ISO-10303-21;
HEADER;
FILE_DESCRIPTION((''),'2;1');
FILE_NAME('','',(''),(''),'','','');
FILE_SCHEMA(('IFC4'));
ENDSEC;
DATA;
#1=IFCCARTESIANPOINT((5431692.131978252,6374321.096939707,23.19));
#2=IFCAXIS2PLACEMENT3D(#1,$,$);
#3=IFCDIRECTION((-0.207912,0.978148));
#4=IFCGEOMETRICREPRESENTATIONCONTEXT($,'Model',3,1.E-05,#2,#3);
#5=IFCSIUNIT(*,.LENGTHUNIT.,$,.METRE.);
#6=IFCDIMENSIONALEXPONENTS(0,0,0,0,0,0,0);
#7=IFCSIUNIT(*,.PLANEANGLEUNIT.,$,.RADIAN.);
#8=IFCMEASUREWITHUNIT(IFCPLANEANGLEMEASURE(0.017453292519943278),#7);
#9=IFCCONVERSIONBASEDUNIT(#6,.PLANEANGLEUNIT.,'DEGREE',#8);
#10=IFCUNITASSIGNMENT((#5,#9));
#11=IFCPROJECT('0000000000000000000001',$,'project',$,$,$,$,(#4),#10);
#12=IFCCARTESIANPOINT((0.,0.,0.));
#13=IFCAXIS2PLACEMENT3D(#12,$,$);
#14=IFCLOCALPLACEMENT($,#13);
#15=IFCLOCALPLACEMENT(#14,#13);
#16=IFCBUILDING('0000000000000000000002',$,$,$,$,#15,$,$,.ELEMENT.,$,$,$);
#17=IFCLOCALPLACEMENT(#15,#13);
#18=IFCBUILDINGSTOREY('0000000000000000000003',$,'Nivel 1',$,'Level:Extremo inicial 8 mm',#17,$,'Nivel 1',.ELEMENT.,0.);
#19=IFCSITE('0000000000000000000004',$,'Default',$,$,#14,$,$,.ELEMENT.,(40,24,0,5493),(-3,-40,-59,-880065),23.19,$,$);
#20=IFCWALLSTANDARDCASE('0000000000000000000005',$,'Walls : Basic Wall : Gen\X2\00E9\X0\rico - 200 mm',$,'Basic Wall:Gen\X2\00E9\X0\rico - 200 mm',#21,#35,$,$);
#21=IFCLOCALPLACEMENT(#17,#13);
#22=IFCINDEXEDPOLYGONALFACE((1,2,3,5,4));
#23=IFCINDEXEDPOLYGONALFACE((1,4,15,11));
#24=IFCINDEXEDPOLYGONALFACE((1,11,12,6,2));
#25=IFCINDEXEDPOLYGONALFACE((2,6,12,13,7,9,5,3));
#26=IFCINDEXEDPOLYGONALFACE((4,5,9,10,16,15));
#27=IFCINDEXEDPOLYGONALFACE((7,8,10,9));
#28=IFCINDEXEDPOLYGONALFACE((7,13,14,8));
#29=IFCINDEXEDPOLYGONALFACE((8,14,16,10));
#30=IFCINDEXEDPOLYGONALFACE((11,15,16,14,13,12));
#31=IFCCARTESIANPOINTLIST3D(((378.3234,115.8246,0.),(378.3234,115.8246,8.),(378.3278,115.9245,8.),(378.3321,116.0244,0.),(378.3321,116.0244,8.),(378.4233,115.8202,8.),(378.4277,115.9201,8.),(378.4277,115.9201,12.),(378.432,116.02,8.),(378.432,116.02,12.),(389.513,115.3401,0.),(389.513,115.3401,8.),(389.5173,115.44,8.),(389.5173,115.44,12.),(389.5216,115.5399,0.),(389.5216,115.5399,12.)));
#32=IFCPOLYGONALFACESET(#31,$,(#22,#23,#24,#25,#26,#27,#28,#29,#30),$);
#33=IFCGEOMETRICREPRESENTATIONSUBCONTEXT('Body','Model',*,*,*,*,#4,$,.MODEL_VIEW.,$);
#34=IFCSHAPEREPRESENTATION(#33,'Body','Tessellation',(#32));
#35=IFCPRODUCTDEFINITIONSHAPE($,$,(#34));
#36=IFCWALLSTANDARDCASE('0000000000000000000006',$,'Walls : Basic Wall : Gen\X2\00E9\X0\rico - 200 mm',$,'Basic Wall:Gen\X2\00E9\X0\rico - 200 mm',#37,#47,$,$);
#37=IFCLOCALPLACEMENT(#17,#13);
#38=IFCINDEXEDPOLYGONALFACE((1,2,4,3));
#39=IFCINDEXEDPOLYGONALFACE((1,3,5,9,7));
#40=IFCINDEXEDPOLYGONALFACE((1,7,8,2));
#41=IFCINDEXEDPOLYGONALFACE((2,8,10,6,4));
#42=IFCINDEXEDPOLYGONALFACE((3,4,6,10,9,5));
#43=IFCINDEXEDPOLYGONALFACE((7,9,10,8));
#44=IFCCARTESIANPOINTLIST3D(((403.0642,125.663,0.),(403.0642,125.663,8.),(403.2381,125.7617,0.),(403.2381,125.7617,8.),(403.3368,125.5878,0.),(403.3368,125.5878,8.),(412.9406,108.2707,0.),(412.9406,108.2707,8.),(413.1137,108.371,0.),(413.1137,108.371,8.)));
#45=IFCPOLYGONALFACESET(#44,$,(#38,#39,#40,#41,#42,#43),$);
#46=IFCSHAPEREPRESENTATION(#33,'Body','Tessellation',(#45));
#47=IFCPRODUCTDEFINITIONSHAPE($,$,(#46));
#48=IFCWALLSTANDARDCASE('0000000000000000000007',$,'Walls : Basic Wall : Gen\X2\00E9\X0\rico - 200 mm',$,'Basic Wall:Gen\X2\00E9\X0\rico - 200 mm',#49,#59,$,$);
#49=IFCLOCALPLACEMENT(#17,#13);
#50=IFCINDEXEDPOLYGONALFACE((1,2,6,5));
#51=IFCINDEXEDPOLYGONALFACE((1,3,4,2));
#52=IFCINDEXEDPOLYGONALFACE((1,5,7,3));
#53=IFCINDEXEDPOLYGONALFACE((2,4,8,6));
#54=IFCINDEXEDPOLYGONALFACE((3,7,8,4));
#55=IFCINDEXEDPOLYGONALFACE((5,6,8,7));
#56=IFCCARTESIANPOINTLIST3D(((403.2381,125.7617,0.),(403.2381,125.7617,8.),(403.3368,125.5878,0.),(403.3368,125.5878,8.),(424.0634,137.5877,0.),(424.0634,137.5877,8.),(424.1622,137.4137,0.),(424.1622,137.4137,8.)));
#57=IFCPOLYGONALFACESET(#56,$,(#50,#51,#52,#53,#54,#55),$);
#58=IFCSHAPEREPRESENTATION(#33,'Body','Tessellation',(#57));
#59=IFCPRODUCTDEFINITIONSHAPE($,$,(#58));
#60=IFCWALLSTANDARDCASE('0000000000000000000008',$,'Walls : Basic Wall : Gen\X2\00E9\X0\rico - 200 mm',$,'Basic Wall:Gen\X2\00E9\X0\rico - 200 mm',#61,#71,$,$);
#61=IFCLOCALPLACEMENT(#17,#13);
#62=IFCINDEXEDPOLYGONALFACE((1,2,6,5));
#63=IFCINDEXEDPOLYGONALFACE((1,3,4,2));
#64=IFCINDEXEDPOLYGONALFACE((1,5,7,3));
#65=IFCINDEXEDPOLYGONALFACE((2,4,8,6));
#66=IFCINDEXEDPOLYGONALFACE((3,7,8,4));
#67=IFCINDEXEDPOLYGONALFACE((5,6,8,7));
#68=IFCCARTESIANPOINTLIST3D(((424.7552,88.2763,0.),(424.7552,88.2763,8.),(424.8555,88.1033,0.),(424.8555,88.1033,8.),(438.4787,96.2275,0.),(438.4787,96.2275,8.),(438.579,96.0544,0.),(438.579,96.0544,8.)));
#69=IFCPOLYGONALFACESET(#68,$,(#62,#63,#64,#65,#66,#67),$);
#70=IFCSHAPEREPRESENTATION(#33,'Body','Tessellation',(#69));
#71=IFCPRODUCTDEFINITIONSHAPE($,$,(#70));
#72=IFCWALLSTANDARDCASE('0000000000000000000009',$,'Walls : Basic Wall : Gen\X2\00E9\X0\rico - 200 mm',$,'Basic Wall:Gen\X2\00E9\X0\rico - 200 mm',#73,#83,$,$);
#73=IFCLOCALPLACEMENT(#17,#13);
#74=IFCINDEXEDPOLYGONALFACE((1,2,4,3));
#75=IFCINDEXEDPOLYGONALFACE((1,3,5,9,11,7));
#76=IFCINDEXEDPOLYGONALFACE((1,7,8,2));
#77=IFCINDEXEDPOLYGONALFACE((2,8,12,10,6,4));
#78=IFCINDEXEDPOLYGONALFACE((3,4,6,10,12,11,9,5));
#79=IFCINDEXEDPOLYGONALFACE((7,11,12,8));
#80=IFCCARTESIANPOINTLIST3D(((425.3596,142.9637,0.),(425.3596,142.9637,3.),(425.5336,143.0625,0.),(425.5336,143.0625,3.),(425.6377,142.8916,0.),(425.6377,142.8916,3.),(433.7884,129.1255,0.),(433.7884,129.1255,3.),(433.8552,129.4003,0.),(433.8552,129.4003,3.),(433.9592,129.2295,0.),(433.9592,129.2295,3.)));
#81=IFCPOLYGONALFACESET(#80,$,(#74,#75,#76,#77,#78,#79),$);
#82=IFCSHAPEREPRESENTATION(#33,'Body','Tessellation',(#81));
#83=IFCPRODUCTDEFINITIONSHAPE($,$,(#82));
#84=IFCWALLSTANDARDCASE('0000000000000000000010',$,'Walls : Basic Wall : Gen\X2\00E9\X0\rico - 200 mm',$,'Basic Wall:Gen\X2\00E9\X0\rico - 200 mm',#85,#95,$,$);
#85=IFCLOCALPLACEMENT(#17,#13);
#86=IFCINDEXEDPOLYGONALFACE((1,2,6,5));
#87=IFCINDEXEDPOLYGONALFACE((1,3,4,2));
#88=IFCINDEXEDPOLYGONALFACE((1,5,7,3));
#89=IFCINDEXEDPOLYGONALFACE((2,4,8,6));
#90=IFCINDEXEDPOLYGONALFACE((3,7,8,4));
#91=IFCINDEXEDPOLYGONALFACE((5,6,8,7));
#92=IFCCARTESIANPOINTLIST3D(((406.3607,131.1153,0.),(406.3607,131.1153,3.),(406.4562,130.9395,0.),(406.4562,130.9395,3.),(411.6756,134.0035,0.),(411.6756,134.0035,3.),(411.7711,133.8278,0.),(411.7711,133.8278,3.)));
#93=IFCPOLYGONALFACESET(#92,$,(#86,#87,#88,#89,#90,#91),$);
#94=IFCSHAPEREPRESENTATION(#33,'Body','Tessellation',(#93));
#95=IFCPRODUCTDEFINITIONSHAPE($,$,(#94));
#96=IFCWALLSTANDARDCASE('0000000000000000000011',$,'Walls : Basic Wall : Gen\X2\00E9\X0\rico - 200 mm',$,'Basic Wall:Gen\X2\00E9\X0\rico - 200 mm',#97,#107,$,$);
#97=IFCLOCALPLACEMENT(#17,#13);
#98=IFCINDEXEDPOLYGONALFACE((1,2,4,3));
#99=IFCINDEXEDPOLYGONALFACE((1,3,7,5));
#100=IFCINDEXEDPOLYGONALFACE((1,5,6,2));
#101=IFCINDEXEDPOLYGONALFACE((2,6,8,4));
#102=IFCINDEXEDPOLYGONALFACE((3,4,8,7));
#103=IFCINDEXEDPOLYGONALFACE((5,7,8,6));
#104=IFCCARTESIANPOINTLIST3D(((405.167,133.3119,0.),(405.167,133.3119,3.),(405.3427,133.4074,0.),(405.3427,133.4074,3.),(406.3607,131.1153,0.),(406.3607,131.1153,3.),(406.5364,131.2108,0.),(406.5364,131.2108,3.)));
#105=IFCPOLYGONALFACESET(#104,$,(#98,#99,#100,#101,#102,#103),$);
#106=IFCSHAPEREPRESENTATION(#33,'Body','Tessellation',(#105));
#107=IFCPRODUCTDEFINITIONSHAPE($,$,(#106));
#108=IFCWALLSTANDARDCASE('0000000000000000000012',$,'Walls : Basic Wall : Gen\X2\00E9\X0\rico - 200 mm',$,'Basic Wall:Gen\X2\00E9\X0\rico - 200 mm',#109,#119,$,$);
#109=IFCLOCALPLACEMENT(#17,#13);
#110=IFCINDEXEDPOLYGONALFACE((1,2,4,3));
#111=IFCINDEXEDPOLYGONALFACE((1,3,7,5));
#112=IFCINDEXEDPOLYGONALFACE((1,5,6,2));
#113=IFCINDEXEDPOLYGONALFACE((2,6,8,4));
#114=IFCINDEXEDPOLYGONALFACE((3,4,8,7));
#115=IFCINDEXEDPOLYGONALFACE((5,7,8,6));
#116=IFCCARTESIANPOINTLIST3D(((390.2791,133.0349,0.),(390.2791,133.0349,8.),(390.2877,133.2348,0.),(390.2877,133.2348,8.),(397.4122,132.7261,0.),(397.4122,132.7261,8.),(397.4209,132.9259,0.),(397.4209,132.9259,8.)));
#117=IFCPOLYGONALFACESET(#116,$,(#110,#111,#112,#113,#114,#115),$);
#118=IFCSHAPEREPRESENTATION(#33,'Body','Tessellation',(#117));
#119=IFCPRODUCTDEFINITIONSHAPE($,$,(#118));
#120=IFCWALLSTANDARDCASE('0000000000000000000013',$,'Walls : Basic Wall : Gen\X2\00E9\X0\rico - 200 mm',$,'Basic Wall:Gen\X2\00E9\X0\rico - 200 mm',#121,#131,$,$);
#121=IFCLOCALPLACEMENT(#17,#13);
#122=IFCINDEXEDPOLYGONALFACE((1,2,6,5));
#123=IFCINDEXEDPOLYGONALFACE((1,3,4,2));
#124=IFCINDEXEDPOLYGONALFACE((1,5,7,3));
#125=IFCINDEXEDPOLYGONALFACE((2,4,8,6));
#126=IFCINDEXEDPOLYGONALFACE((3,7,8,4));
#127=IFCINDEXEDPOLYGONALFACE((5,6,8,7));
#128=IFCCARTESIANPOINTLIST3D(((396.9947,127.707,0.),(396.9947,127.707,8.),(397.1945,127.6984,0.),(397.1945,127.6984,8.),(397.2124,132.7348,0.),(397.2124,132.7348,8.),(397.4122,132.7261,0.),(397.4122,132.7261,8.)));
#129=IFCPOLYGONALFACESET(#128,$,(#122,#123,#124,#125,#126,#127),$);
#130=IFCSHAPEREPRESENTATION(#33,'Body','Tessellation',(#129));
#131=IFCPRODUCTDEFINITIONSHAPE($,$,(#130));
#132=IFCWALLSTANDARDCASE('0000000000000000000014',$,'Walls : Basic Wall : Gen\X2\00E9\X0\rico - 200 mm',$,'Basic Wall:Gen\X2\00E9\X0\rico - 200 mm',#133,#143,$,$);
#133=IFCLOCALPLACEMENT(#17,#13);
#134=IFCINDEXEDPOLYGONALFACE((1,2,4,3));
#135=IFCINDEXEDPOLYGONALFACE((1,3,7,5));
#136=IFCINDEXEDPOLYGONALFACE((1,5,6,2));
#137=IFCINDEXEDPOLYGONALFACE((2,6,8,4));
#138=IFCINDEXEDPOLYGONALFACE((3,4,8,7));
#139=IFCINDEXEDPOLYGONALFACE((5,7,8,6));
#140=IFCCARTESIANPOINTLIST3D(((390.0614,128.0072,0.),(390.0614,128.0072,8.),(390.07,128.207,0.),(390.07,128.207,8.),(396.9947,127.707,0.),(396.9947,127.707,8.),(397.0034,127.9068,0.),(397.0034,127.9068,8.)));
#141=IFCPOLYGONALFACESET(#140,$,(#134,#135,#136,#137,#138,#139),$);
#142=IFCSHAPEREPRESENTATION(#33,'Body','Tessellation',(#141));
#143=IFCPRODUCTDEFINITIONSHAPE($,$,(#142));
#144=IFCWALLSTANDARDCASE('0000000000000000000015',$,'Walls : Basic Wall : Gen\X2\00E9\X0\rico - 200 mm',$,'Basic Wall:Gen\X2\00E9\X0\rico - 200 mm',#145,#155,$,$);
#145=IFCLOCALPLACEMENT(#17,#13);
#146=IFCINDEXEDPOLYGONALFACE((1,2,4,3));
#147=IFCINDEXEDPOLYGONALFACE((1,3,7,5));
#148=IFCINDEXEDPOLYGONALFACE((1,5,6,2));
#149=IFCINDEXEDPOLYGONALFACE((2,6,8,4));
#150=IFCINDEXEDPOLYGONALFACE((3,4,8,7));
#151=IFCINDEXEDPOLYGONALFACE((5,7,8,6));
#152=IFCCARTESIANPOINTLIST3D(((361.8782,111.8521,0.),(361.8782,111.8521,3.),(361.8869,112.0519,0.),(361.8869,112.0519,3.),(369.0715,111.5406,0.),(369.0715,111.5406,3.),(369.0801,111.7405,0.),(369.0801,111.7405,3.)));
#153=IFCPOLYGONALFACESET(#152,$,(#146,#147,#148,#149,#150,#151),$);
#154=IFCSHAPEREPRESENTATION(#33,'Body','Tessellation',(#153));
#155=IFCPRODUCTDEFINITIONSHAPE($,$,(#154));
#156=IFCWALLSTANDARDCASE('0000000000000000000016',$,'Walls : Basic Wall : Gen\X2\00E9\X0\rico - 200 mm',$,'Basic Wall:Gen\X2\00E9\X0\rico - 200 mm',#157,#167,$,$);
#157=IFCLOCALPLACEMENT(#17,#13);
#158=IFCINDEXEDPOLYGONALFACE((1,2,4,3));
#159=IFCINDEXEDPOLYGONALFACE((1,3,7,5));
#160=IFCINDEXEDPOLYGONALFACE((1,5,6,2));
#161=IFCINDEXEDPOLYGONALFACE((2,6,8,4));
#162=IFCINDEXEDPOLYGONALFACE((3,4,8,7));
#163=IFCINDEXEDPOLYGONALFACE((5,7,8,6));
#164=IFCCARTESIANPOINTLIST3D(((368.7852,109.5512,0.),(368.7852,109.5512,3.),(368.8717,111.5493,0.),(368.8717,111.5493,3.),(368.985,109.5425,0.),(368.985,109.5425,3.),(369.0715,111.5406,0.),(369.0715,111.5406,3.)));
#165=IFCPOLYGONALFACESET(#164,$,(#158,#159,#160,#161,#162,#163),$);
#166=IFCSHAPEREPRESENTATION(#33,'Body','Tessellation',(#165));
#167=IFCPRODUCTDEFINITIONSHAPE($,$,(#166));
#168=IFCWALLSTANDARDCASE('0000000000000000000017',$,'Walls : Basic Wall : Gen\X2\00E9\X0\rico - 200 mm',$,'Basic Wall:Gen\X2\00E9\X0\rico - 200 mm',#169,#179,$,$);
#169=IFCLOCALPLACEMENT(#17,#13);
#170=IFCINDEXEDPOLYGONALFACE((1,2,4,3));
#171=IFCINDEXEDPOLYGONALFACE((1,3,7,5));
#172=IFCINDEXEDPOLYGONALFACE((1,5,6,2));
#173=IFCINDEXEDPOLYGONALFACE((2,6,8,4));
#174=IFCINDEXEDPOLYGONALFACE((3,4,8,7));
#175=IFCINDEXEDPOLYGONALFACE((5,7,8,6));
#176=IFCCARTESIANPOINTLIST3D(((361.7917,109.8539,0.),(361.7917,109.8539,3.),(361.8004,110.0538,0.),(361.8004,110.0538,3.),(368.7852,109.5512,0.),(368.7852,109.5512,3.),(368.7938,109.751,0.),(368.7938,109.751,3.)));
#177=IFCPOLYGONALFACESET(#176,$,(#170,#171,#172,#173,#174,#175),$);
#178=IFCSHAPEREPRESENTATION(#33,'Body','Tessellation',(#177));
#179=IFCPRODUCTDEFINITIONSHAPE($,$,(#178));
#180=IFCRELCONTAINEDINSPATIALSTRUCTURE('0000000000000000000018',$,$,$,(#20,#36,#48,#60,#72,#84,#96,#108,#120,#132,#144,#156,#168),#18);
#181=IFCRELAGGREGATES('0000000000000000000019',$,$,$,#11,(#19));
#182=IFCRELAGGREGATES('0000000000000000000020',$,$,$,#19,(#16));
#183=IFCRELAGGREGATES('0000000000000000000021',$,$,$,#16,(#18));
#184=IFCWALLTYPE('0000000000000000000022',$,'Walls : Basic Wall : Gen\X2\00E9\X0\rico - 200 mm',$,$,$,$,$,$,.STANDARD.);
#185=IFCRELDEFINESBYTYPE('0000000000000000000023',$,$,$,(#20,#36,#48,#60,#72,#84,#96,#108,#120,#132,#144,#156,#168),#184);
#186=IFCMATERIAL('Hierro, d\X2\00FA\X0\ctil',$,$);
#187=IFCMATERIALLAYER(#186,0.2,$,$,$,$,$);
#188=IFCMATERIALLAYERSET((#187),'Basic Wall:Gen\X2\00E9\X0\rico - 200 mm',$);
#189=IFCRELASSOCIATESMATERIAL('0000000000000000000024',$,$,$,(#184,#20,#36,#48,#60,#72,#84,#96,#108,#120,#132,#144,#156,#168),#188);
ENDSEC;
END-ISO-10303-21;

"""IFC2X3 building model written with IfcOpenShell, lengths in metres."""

from ifc_helpers import new_model, entity, si_unit, converted_unit, direction, frame, frame_2d, origin, place, context, subcontext, project, spatial, polyline, rectangle, outline, extrude, clip, bounded_halfspace, material, layer, layer_set, layer_usage, type_object, element, save


model = new_model("IFC2X3")

# Units and contexts
model_context = context("Model", 3, precision=1e-05, world=frame((5431692.131978252, 6374321.096939707, 23.19)), true_north=direction((-0.207912, 0.978148)))
body_context = subcontext(model_context, "Body", "Model", "MODEL_VIEW")
ifc_project = project(units=[si_unit("LENGTHUNIT", "METRE"), converted_unit("PLANEANGLEUNIT", "DEGREE", entity("IfcPlaneAngleMeasure", 0.017453292519943278), si_unit("PLANEANGLEUNIT", "RADIAN"), dimensions=[0, 0, 0, 0, 0, 0, 0])], contexts=[model_context])

# Site, building, storey
site_placement = place(None, origin())
site = spatial("IfcSite", under=ifc_project, at=site_placement, Name="Default", CompositionType="ELEMENT", RefLatitude=(40, 24, 0, 5493), RefLongitude=(-3, -40, -59, -880065), RefElevation=23.19)
building_placement = place(site_placement, origin())
building = spatial("IfcBuilding", under=site, at=building_placement, CompositionType="ELEMENT")
storey_placement = place(building_placement, origin())
storey = spatial("IfcBuildingStorey", under=building, at=storey_placement, Name="Nivel 1", ObjectType="Level:Extremo inicial 8 mm", LongName="Nivel 1", CompositionType="ELEMENT", Elevation=0.0)

# Walls
ifc_material = material(Name="Hierro, dúctil")
ifc_layer = layer(ifc_material, 0.2)
ifc_layer_set = layer_set([ifc_layer], Name="Basic Wall:Genérico - 200 mm")
wall_type = type_object("IfcWallType", Name="Walls : Basic Wall : Genérico - 200 mm", PredefinedType="STANDARD", material=ifc_layer_set)
ifc_layer_usage_1 = layer_usage(ifc_layer_set, "AXIS2", "NEGATIVE", 0.1)
wall_1_placement = place(storey_placement, frame((389.5173, 115.44, 0.0), z_axis=(0.0, 0.0, 1.0), x_axis=(-0.999064, 0.043255, 0.0)))
element("IfcWallStandardCase", 1, at=wall_1_placement, inside=storey, type_object=wall_type, material=ifc_layer_usage_1, Name="Walls : Basic Wall : Genérico - 200 mm", ObjectType="Basic Wall:Genérico - 200 mm", context=body_context, shape_type="Clipping", body=[
    clip(clip(clip(clip(extrude(rectangle(XDim=11.2, YDim=0.2, at=frame_2d((5.6, 0.0), x_axis=(-1.0, 0.0))), origin(), (0.0, 0.0, 1.0), 12.0), bounded_halfspace(frame((0.0, -0.1, 12.0), z_axis=(0.0, 0.0, 1.0), x_axis=(-0.999064, -0.043255, 0.0)), False, frame((0.0, -0.1, 12.0)), polyline([(0.0, 0.0), (0.2, 0.0), (11.1, 0.0), (11.1, 0.1), (0.0, 0.1), (0.0, 0.0)]))), bounded_halfspace(frame((11.1, -0.1, 8.0), z_axis=(0.0, 0.0, 1.0), x_axis=(0.0, 1.0, 0.0)), False, frame((11.1, -0.1, 8.0)), polyline([(0.0, 0.0), (0.1, 0.0), (0.1, 0.1), (0.0, 0.1), (0.0, 0.0)]))), bounded_halfspace(frame((11.1, 0.1, 8.0), z_axis=(0.0, 0.0, 1.0), x_axis=(0.0, 1.0, 0.0)), False, frame((11.1, 0.1, 8.0)), polyline([(0.0, 0.0), (-11.1, 0.0), (-11.1, -0.1), (0.0, -0.1), (0.0, 0.0)]))), bounded_halfspace(frame((11.2, 0.0, 8.0), z_axis=(0.0, 0.0, 1.0), x_axis=(0.0, 1.0, 0.0)), False, frame((11.2, 0.0, 8.0)), polyline([(0.0, 0.0), (0.0, 0.1), (-0.1, 0.1), (-0.1, 0.0), (0.0, 0.0)]))),
])
ifc_layer_usage_2 = layer_usage(ifc_layer_set, "AXIS2", "NEGATIVE", 0.1)
wall_2_placement = place(storey_placement, frame((413.0276, 108.3201, 0.0), z_axis=(0.0, 0.0, 1.0), x_axis=(-0.4938, 0.869576, 0.0)))
element("IfcWallStandardCase", 2, at=wall_2_placement, inside=storey, type_object=wall_type, material=ifc_layer_usage_2, Name="Walls : Basic Wall : Genérico - 200 mm", ObjectType="Basic Wall:Genérico - 200 mm", context=body_context, shape_type="SweptSolid", body=[
    extrude(outline(polyline([(20.0009, -0.1), (20.0009, 0.1), (0.0, 0.1), (0.0017, -0.1), (19.8009, -0.1), (20.0009, -0.1)])), origin(), (0.0, 0.0, 1.0), 8.0),
])
ifc_layer_usage_3 = layer_usage(ifc_layer_set, "AXIS2", "NEGATIVE", 0.1)
wall_3_placement = place(storey_placement, frame((403.2875, 125.6748, 0.0), z_axis=(0.0, 0.0, 1.0), x_axis=(0.869576, 0.4938, 0.0)))
element("IfcWallStandardCase", 3, at=wall_3_placement, inside=storey, type_object=wall_type, material=ifc_layer_usage_3, Name="Walls : Basic Wall : Genérico - 200 mm", ObjectType="Basic Wall:Genérico - 200 mm", context=body_context, shape_type="SweptSolid", body=[
    extrude(rectangle(XDim=23.9488, YDim=0.2, at=frame_2d((11.9744, 0.0), x_axis=(-1.0, 0.0))), origin(), (0.0, 0.0, 1.0), 8.0),
])
ifc_layer_usage_4 = layer_usage(ifc_layer_set, "AXIS2", "NEGATIVE", 0.1)
wall_4_placement = place(storey_placement, frame((424.8053, 88.1898, 0.0), z_axis=(0.0, 0.0, 1.0), x_axis=(0.865262, 0.50132, 0.0)))
element("IfcWallStandardCase", 4, at=wall_4_placement, inside=storey, type_object=wall_type, material=ifc_layer_usage_4, Name="Walls : Basic Wall : Genérico - 200 mm", ObjectType="Basic Wall:Genérico - 200 mm", context=body_context, shape_type="SweptSolid", body=[
    extrude(rectangle(XDim=15.8605, YDim=0.2, at=frame_2d((7.9302, 0.0), x_axis=(-1.0, 0.0))), origin(), (0.0, 0.0, 1.0), 8.0),
])
ifc_layer_usage_5 = layer_usage(ifc_layer_set, "AXIS2", "NEGATIVE", 0.1)
wall_5_placement = place(storey_placement, frame((433.8738, 129.1775, 0.0), z_axis=(0.0, 0.0, 1.0), x_axis=(-0.520198, 0.854046, 0.0)))
element("IfcWallStandardCase", 5, at=wall_5_placement, inside=storey, type_object=wall_type, material=ifc_layer_usage_5, Name="Walls : Basic Wall : Genérico - 200 mm", ObjectType="Basic Wall:Genérico - 200 mm", context=body_context, shape_type="SweptSolid", body=[
    extrude(outline(polyline([(16.197, -0.1), (16.2031, 0.1), (0.0, 0.1), (0.0, -0.1), (0.2, -0.1), (15.9969, -0.1), (16.197, -0.1)])), origin(), (0.0, 0.0, 1.0), 3.0),
])
ifc_layer_usage_6 = layer_usage(ifc_layer_set, "AXIS2", "NEGATIVE", 0.1)
wall_6_placement = place(storey_placement, frame((411.7233, 133.9157, 0.0), z_axis=(0.0, 0.0, 1.0), x_axis=(-0.878643, -0.47748, 0.0)))
element("IfcWallStandardCase", 6, at=wall_6_placement, inside=storey, type_object=wall_type, material=ifc_layer_usage_6, Name="Walls : Basic Wall : Genérico - 200 mm", ObjectType="Basic Wall:Genérico - 200 mm", context=body_context, shape_type="SweptSolid", body=[
    extrude(rectangle(XDim=6.049, YDim=0.2, at=frame_2d((3.0245, 0.0), x_axis=(-1.0, 0.0))), origin(), (0.0, 0.0, 1.0), 3.0),
])
ifc_layer_usage_7 = layer_usage(ifc_layer_set, "AXIS2", "NEGATIVE", 0.1)
wall_7_placement = place(storey_placement, frame((405.2549, 133.3596, 0.0), z_axis=(0.0, 0.0, 1.0), x_axis=(0.47748, -0.878643, 0.0)))
element("IfcWallStandardCase", 7, at=wall_7_placement, inside=storey, type_object=wall_type, material=ifc_layer_usage_7, Name="Walls : Basic Wall : Genérico - 200 mm", ObjectType="Basic Wall:Genérico - 200 mm", context=body_context, shape_type="Clipping", body=[
    clip(extrude(rectangle(XDim=2.5, YDim=0.2, at=frame_2d((1.25, 0.0), x_axis=(-1.0, 0.0))), origin(), (0.0, 0.0, 1.0), 3.0), bounded_halfspace(frame((0.0, -0.1, 3.0), z_axis=(0.0, 0.0, 1.0), x_axis=(0.47748, 0.878643, 0.0)), False, frame((0.0, -0.1, 3.0)), polyline([(0.0, 0.0), (2.5, 0.0), (2.5, 0.2), (0.0, 0.2), (0.0, 0.0)]))),
])
ifc_layer_usage_8 = layer_usage(ifc_layer_set, "AXIS2", "NEGATIVE", 0.1)
wall_8_placement = place(storey_placement, frame((390.2834, 133.1349, 0.0), z_axis=(0.0, 0.0, 1.0), x_axis=(0.999064, -0.043255, 0.0)))
element("IfcWallStandardCase", 8, at=wall_8_placement, inside=storey, type_object=wall_type, material=ifc_layer_usage_8, Name="Walls : Basic Wall : Genérico - 200 mm", ObjectType="Basic Wall:Genérico - 200 mm", context=body_context, shape_type="SweptSolid", body=[
    extrude(rectangle(XDim=7.1398, YDim=0.2, at=frame_2d((3.5699, 0.0), x_axis=(-1.0, 0.0))), origin(), (0.0, 0.0, 1.0), 8.0),
])
ifc_layer_usage_9 = layer_usage(ifc_layer_set, "AXIS2", "NEGATIVE", 0.1)
wall_9_placement = place(storey_placement, frame((397.3123, 132.7304, 0.0), z_axis=(0.0, 0.0, 1.0), x_axis=(-0.043255, -0.999064, 0.0)))
element("IfcWallStandardCase", 9, at=wall_9_placement, inside=storey, type_object=wall_type, material=ifc_layer_usage_9, Name="Walls : Basic Wall : Genérico - 200 mm", ObjectType="Basic Wall:Genérico - 200 mm", context=body_context, shape_type="SweptSolid", body=[
    extrude(rectangle(XDim=5.0325, YDim=0.2, at=frame_2d((2.5162, 0.0), x_axis=(-1.0, 0.0))), origin(), (0.0, 0.0, 1.0), 8.0),
])
ifc_layer_usage_10 = layer_usage(ifc_layer_set, "AXIS2", "NEGATIVE", 0.1)
wall_10_placement = place(storey_placement, frame((396.999, 127.8069, 0.0), z_axis=(0.0, 0.0, 1.0), x_axis=(-0.999064, 0.043255, 0.0)))
element("IfcWallStandardCase", 10, at=wall_10_placement, inside=storey, type_object=wall_type, material=ifc_layer_usage_10, Name="Walls : Basic Wall : Genérico - 200 mm", ObjectType="Basic Wall:Genérico - 200 mm", context=body_context, shape_type="SweptSolid", body=[
    extrude(rectangle(XDim=6.9398, YDim=0.2, at=frame_2d((3.4699, 0.0), x_axis=(-1.0, 0.0))), origin(), (0.0, 0.0, 1.0), 8.0),
])
ifc_layer_usage_11 = layer_usage(ifc_layer_set, "AXIS2", "NEGATIVE", 0.1)
wall_11_placement = place(storey_placement, frame((361.8826, 111.952, 0.0), z_axis=(0.0, 0.0, 1.0), x_axis=(0.999064, -0.043255, 0.0)))
element("IfcWallStandardCase", 11, at=wall_11_placement, inside=storey, type_object=wall_type, material=ifc_layer_usage_11, Name="Walls : Basic Wall : Genérico - 200 mm", ObjectType="Basic Wall:Genérico - 200 mm", context=body_context, shape_type="SweptSolid", body=[
    extrude(rectangle(XDim=7.2, YDim=0.2, at=frame_2d((3.6, 0.0), x_axis=(-1.0, 0.0))), origin(), (0.0, 0.0, 1.0), 3.0),
])
ifc_layer_usage_12 = layer_usage(ifc_layer_set, "AXIS2", "NEGATIVE", 0.1)
wall_12_placement = place(storey_placement, frame((368.9716, 111.545, 0.0), z_axis=(0.0, 0.0, 1.0), x_axis=(-0.043255, -0.999064, 0.0)))
element("IfcWallStandardCase", 12, at=wall_12_placement, inside=storey, type_object=wall_type, material=ifc_layer_usage_12, Name="Walls : Basic Wall : Genérico - 200 mm", ObjectType="Basic Wall:Genérico - 200 mm", context=body_context, shape_type="SweptSolid", body=[
    extrude(rectangle(XDim=2.0, YDim=0.2, at=frame_2d((1.0, 0.0), x_axis=(-1.0, 0.0))), origin(), (0.0, 0.0, 1.0), 3.0),
])
ifc_layer_usage_13 = layer_usage(ifc_layer_set, "AXIS2", "NEGATIVE", 0.1)
wall_13_placement = place(storey_placement, frame((368.7895, 109.6511, 0.0), z_axis=(0.0, 0.0, 1.0), x_axis=(-0.999064, 0.043255, 0.0)))
element("IfcWallStandardCase", 13, at=wall_13_placement, inside=storey, type_object=wall_type, material=ifc_layer_usage_13, Name="Walls : Basic Wall : Genérico - 200 mm", ObjectType="Basic Wall:Genérico - 200 mm", context=body_context, shape_type="SweptSolid", body=[
    extrude(rectangle(XDim=7.0, YDim=0.2, at=frame_2d((3.5, 0.0), x_axis=(-1.0, 0.0))), origin(), (0.0, 0.0, 1.0), 3.0),
])

save(model, "model.ifc")
